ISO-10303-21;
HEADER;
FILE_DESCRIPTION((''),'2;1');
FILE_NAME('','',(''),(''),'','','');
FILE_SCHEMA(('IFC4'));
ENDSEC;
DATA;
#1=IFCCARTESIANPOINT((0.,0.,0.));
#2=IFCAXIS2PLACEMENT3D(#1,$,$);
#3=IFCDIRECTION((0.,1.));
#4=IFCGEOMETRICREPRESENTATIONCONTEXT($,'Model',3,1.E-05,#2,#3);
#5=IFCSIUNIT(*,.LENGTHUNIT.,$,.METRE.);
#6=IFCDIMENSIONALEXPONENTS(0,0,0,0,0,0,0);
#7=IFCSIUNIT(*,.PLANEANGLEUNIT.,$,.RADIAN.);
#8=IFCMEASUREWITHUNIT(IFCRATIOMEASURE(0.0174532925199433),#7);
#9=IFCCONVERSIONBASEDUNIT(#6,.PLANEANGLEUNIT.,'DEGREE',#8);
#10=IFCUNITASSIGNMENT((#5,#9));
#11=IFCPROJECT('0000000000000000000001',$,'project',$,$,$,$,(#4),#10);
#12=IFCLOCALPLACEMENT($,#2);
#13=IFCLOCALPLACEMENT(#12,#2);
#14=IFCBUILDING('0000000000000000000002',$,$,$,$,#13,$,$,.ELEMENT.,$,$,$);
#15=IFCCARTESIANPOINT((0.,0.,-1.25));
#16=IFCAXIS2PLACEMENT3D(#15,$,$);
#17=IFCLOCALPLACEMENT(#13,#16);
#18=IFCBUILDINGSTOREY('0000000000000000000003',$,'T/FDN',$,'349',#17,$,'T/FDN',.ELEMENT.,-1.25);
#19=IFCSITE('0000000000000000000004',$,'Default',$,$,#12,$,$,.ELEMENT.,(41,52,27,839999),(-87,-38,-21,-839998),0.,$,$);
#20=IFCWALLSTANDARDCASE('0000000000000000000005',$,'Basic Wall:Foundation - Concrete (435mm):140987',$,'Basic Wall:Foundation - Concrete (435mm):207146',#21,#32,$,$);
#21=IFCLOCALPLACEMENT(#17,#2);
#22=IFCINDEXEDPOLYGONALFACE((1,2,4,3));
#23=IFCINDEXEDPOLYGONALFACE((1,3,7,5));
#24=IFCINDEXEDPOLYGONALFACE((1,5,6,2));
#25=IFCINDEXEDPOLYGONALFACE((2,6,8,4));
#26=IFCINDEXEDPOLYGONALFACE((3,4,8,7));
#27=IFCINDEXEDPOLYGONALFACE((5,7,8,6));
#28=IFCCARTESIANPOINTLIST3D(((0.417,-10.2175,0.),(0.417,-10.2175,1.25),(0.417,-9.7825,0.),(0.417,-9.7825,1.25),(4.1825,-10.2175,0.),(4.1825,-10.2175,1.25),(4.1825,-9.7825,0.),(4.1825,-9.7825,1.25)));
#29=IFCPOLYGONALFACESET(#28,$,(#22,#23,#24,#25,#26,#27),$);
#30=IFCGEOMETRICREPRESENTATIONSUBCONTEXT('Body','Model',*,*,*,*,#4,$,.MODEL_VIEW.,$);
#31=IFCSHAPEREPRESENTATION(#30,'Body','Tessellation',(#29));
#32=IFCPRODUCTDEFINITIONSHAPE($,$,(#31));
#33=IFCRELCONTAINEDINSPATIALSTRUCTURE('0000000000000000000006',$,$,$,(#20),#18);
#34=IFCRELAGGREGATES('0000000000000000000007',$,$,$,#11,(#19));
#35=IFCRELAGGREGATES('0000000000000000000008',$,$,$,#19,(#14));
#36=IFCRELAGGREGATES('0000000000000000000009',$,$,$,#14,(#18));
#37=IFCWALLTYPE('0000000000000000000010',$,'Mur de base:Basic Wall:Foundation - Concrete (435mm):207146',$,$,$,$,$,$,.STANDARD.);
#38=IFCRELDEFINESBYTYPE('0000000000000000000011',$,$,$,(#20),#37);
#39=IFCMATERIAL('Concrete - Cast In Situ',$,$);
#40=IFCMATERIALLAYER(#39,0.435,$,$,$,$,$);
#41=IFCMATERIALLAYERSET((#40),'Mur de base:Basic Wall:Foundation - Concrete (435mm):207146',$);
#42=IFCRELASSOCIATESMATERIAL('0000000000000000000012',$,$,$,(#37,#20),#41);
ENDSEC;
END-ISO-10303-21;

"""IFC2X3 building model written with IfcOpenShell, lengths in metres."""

from ifc_helpers import new_model, entity, si_unit, converted_unit, direction, frame, frame_2d, origin, place, context, subcontext, project, spatial, rectangle, extrude, material, layer, layer_set, layer_usage, type_object, element, save


model = new_model("IFC2X3")

# Units and contexts
model_context = context("Model", 3, precision=1e-05, world=origin(), true_north=direction((0.0, 1.0)))
body_context = subcontext(model_context, "Body", "Model", "MODEL_VIEW")
ifc_project = project(units=[si_unit("LENGTHUNIT", "METRE"), converted_unit("PLANEANGLEUNIT", "DEGREE", entity("IfcRatioMeasure", 0.0174532925199433), si_unit("PLANEANGLEUNIT", "RADIAN"), dimensions=[0, 0, 0, 0, 0, 0, 0])], contexts=[model_context])

# Site, building, storey
site_placement = place(None, origin())
site = spatial("IfcSite", under=ifc_project, at=site_placement, Name="Default", CompositionType="ELEMENT", RefLatitude=(41, 52, 27, 839999), RefLongitude=(-87, -38, -21, -839998), RefElevation=0.0)
building_placement = place(site_placement, origin())
building = spatial("IfcBuilding", under=site, at=building_placement, CompositionType="ELEMENT")
storey_placement = place(building_placement, frame((0.0, 0.0, -1.25)))
storey = spatial("IfcBuildingStorey", under=building, at=storey_placement, Name="T/FDN", ObjectType="349", LongName="T/FDN", CompositionType="ELEMENT", Elevation=-1.25)

# Shared definitions
ifc_material = material(Name="Concrete - Cast In Situ")

# Wall
ifc_layer_1 = layer(ifc_material, 0.435)
ifc_layer_set_1 = layer_set([ifc_layer_1], Name="Mur de base:Basic Wall:Foundation - Concrete (435mm):207146")
wall_type_1 = type_object("IfcWallType", Name="Mur de base:Basic Wall:Foundation - Concrete (435mm):207146", PredefinedType="STANDARD", material=ifc_layer_set_1)
ifc_layer_usage_1 = layer_usage(ifc_layer_set_1, "AXIS2", "NEGATIVE", 0.2175)
wall_1_placement = place(storey_placement, frame((0.417, -10.0, 0.0)))
element("IfcWallStandardCase", 1, at=wall_1_placement, inside=storey, type_object=wall_type_1, material=ifc_layer_usage_1, Name="Basic Wall:Foundation - Concrete (435mm):140987", ObjectType="Basic Wall:Foundation - Concrete (435mm):207146", context=body_context, shape_type="SweptSolid", body=[
    extrude(rectangle(XDim=3.7655, YDim=0.435, at=frame_2d((1.8827, 0.0), x_axis=(-1.0, 0.0))), origin(), (0.0, 0.0, 1.0), 1.25),
])

save(model, "model.ifc")
